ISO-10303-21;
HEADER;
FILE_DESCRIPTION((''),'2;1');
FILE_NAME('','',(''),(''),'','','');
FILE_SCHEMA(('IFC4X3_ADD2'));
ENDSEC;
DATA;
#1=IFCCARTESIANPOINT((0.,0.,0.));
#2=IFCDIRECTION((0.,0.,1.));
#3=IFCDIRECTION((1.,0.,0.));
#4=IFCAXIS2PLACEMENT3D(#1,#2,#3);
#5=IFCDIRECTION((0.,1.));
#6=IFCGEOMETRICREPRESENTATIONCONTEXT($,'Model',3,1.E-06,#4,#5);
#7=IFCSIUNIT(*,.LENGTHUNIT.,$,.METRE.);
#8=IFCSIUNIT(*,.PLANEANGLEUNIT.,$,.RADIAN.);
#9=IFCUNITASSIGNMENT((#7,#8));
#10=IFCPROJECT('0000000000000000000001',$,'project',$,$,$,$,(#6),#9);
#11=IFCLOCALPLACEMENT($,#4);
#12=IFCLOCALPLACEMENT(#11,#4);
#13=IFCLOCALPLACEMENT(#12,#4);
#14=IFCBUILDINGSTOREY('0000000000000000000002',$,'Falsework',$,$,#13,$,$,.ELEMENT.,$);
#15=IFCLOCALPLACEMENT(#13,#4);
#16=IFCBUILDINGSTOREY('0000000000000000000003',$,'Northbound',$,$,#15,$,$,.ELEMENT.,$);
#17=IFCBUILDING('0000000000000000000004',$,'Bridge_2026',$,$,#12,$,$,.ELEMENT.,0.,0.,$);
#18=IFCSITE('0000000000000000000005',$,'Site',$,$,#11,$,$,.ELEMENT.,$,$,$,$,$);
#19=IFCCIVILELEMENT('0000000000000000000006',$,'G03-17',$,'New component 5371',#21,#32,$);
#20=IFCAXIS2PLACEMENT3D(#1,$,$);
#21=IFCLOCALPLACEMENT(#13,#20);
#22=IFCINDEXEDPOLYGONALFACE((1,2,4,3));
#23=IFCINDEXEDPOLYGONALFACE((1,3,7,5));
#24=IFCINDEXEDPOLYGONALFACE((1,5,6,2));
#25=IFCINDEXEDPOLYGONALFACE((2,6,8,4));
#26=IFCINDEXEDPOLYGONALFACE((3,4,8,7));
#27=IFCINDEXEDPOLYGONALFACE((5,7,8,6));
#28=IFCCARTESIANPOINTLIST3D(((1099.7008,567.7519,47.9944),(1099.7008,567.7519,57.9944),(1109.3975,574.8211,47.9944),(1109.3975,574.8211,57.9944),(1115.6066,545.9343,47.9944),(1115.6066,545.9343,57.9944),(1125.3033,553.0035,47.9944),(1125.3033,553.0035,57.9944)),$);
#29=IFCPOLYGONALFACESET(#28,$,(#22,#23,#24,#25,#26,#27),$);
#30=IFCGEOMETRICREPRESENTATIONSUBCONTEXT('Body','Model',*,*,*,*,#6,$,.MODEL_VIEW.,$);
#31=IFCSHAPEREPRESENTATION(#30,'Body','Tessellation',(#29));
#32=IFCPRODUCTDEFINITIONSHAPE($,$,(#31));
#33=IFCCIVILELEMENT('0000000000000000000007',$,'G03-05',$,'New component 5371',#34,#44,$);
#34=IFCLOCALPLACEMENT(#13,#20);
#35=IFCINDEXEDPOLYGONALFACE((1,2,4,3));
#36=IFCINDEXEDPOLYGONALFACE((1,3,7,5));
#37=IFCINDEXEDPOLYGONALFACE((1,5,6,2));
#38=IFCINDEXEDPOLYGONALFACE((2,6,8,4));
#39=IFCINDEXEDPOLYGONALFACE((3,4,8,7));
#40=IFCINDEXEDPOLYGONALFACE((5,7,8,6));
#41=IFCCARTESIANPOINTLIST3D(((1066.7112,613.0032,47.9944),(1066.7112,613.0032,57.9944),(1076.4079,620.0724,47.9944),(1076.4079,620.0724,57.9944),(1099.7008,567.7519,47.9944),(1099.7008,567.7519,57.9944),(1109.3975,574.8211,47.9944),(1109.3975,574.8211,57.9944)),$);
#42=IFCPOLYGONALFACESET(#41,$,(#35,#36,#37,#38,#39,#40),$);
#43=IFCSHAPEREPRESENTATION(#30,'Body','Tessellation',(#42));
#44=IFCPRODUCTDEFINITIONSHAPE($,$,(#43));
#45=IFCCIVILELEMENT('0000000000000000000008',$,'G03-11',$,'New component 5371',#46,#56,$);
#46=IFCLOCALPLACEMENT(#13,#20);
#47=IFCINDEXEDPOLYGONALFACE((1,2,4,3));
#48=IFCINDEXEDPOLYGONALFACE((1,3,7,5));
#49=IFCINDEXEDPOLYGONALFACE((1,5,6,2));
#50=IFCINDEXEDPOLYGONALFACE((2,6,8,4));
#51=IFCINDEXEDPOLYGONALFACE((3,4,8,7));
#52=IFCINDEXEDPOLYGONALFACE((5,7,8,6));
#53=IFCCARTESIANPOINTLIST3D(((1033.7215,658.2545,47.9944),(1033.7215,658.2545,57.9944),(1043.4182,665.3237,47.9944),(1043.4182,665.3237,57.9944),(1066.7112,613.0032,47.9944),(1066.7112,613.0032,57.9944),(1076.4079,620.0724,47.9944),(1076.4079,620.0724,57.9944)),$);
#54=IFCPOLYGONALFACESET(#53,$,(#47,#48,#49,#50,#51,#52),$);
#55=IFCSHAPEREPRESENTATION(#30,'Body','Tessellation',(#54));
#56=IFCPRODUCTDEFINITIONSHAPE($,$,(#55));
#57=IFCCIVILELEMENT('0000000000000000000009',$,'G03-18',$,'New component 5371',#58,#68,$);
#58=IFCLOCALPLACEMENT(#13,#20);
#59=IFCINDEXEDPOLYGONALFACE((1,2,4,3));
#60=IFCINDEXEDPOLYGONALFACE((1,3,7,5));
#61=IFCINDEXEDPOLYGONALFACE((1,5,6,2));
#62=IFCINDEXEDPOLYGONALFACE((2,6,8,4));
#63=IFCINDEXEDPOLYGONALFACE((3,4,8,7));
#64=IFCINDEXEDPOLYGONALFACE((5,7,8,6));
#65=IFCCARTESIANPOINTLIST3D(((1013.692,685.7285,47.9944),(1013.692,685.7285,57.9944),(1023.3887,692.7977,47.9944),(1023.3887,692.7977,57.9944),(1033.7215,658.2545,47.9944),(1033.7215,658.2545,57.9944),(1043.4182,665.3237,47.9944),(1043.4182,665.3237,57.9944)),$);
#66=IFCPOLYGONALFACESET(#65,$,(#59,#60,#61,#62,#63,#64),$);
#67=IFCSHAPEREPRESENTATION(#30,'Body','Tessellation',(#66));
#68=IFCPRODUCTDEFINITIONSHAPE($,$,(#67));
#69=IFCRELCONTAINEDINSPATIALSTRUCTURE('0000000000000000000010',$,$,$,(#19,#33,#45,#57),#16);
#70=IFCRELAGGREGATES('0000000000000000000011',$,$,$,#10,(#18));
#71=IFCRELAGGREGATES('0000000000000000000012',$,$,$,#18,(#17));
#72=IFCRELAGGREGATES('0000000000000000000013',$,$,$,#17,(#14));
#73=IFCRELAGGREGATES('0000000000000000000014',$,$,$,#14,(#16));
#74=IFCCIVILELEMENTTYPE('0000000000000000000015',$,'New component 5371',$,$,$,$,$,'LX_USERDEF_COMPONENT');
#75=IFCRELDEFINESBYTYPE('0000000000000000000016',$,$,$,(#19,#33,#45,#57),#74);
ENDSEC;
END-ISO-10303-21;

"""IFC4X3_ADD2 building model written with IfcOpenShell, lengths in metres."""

from ifc_helpers import new_model, si_unit, direction, frame, frame_2d, origin_with_axes, place, context, subcontext, project, spatial, rectangle, extrude, type_object, element, save


model = new_model("IFC4X3_ADD2")

# Units and contexts
model_context = context("Model", 3, precision=1e-06, world=origin_with_axes(), true_north=direction((0.0, 1.0)))
body_context = subcontext(model_context, "Body", "Model", "MODEL_VIEW")
ifc_project = project(units=[si_unit("LENGTHUNIT", "METRE"), si_unit("PLANEANGLEUNIT", "RADIAN")], contexts=[model_context])

# Site, building, storeys
site_placement = place(None, origin_with_axes())
site = spatial("IfcSite", under=ifc_project, at=site_placement, Name="Site", CompositionType="ELEMENT")
building_placement = place(site_placement, origin_with_axes())
building = spatial("IfcBuilding", under=site, at=building_placement, Name="Bridge_2026", CompositionType="ELEMENT", ElevationOfRefHeight=0.0, ElevationOfTerrain=0.0)
storey_1_placement = place(building_placement, origin_with_axes())
storey_1 = spatial("IfcBuildingStorey", under=building, at=storey_1_placement, Name="Falsework", CompositionType="ELEMENT")
storey_2_placement = place(storey_1_placement, origin_with_axes())
storey_2 = spatial("IfcBuildingStorey", under=storey_1, at=storey_2_placement, Name="Northbound", CompositionType="ELEMENT")

# Civil elements
civil_element_type = type_object("IfcCivilElementType", Name="New component 5371", ElementType="LX_USERDEF_COMPONENT")
civil_element_1_placement = place(storey_2_placement, frame((1115.6066, 545.9343, 47.9944), z_axis=(0.0, 0.0, 1.0), x_axis=(0.808059, 0.589101, 0.0)))
element("IfcCivilElement", 1, at=civil_element_1_placement, inside=storey_2, type_object=civil_element_type, Name="G03-17", ObjectType="New component 5371", context=body_context, shape_type="SweptSolid", body=[
    extrude(rectangle(XDim=12.0, YDim=27.0, at=frame_2d((6.0, 13.5), x_axis=(1.0, 0.0))), origin_with_axes(), (0.0, 0.0, 1.0), 10.0),
])
for number, where, z_axis, x_axis, name in (
    (2, (1099.7008, 567.7519, 47.9944), (0.0, 0.0, 1.0), (0.808059, 0.589101, 0.0), "G03-05"),
    (3, (1066.7112, 613.0032, 47.9944), (0.0, 0.0, 1.0), (0.808059, 0.589101, 0.0), "G03-11"),
):
    element("IfcCivilElement", number, at=place(storey_2_placement, frame(where, z_axis=z_axis, x_axis=x_axis)), inside=storey_2, type_object=civil_element_type, Name=name, ObjectType="New component 5371", context=body_context, shape_type="SweptSolid", body=[
        extrude(rectangle(XDim=12.0, YDim=56.0, at=frame_2d((6.0, 28.0), x_axis=(1.0, 0.0))), origin_with_axes(), (0.0, 0.0, 1.0), 10.0),
    ])
civil_element_2_placement = place(storey_2_placement, frame((1033.7215, 658.2545, 47.9944), z_axis=(0.0, 0.0, 1.0), x_axis=(0.808059, 0.589101, 0.0)))
element("IfcCivilElement", 4, at=civil_element_2_placement, inside=storey_2, type_object=civil_element_type, Name="G03-18", ObjectType="New component 5371", context=body_context, shape_type="SweptSolid", body=[
    extrude(rectangle(XDim=12.0, YDim=34.0, at=frame_2d((6.0, 17.0), x_axis=(1.0, 0.0))), origin_with_axes(), (0.0, 0.0, 1.0), 10.0),
])

save(model, "model.ifc")
